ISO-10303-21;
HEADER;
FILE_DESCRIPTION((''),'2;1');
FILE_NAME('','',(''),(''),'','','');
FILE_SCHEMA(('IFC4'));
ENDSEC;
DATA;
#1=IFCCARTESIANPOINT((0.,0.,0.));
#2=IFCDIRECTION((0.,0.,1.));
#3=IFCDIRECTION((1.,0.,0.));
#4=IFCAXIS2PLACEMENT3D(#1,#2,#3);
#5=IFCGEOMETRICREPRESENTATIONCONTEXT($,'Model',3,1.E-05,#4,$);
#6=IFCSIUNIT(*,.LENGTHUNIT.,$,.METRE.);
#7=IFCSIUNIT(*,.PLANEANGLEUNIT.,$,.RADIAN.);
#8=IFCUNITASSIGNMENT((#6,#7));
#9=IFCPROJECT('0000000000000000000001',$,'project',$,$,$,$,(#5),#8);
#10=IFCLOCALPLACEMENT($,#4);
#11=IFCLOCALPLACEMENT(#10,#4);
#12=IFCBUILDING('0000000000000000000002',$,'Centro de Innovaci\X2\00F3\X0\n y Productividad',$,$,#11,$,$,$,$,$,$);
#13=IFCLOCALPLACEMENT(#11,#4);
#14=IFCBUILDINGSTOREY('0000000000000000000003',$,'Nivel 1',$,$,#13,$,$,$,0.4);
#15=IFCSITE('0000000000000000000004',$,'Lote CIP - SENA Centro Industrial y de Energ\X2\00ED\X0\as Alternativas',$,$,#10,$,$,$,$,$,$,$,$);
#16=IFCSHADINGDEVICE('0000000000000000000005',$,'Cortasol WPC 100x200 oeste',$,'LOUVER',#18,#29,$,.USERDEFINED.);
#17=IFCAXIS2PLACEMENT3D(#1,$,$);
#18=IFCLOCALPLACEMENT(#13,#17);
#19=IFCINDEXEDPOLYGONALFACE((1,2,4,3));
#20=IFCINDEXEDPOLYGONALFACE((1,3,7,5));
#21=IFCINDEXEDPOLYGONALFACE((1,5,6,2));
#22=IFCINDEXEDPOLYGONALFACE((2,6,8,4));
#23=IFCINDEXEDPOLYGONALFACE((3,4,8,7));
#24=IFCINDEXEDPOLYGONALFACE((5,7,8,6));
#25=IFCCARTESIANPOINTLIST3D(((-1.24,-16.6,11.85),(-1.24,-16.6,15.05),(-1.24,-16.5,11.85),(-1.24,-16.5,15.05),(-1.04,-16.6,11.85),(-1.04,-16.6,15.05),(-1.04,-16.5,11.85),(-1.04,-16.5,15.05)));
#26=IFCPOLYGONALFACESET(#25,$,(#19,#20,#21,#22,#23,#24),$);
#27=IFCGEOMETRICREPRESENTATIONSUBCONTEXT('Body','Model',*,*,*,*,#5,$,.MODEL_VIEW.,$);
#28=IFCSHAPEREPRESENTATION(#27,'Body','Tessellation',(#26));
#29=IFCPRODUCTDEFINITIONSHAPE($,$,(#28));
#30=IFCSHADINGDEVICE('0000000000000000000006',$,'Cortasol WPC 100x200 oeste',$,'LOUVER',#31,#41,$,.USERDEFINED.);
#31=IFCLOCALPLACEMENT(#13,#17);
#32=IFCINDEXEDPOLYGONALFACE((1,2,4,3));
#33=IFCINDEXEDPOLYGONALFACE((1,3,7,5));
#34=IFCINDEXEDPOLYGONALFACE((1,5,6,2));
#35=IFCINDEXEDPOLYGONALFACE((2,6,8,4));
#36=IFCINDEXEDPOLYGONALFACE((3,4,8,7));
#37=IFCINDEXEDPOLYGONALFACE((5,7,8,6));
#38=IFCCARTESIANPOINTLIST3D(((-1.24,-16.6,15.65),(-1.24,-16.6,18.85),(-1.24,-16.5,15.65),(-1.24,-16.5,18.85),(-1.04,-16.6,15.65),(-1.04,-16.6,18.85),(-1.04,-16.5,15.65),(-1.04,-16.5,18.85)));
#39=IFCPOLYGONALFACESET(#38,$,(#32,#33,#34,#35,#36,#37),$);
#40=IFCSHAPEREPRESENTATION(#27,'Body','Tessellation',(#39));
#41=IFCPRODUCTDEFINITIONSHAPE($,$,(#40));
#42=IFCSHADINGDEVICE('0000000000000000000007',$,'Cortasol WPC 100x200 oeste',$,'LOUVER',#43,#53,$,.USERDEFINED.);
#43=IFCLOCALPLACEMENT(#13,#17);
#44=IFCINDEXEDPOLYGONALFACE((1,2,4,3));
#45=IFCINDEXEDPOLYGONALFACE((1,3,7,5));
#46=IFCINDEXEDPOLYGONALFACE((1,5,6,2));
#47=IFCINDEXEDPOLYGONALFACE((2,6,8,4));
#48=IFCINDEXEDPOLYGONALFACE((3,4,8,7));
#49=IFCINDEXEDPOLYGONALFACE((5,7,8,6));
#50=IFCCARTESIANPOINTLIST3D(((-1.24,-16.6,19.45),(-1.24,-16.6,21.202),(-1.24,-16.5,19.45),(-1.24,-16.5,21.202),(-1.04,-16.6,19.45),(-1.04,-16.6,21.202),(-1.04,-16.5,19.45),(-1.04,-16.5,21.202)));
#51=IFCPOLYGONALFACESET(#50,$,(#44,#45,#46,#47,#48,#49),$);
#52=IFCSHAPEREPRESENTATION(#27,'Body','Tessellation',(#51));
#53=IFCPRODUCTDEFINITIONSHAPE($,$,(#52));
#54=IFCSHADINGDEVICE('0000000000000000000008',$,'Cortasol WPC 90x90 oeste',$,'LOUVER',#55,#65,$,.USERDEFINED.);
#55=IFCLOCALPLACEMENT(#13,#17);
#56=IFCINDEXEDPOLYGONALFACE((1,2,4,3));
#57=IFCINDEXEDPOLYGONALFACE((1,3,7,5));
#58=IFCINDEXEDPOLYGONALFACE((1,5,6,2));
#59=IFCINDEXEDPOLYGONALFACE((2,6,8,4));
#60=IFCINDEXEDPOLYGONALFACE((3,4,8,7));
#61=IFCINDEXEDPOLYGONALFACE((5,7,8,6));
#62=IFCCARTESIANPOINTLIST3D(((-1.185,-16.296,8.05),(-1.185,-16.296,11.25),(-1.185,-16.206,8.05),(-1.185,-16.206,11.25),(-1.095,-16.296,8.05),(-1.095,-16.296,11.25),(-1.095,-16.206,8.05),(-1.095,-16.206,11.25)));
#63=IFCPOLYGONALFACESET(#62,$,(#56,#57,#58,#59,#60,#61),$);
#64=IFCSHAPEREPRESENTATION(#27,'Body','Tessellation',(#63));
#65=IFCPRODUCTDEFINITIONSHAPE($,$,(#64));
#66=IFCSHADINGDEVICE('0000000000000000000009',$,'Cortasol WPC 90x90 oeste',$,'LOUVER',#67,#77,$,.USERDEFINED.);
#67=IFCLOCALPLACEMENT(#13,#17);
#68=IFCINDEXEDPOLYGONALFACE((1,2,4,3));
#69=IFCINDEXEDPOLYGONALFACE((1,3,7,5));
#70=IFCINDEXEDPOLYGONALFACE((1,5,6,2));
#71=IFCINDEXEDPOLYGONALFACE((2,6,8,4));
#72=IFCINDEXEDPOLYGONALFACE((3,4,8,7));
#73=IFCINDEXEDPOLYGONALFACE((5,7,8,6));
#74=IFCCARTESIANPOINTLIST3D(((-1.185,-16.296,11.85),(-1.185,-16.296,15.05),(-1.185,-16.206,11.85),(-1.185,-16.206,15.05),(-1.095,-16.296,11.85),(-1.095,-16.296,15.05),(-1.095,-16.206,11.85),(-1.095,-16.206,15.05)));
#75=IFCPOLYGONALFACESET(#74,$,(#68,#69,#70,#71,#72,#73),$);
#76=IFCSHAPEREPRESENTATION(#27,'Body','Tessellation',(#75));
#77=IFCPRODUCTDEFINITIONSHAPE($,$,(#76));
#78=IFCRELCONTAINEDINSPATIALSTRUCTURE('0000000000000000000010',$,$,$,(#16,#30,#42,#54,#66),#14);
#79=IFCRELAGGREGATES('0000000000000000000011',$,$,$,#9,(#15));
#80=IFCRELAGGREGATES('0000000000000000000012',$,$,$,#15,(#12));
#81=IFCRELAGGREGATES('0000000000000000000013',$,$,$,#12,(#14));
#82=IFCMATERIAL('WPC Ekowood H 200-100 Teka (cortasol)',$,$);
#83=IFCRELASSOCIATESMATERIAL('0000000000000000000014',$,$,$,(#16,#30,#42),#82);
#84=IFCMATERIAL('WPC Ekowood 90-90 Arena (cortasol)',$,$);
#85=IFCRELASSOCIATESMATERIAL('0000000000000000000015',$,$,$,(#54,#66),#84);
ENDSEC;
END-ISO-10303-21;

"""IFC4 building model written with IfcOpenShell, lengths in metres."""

from ifc_helpers import new_model, si_unit, frame, origin_with_axes, place, context, subcontext, project, spatial, polyline, outline, extrude, material, element, save


model = new_model("IFC4")

# Units and contexts
model_context = context("Model", 3, precision=1e-05, world=origin_with_axes())
body_context = subcontext(model_context, "Body", "Model", "MODEL_VIEW")
ifc_project = project(units=[si_unit("LENGTHUNIT", "METRE"), si_unit("PLANEANGLEUNIT", "RADIAN")], contexts=[model_context])

# Site, building, storey
site_placement = place(None, origin_with_axes())
site = spatial("IfcSite", under=ifc_project, at=site_placement, Name="Lote CIP - SENA Centro Industrial y de Energías Alternativas")
building_placement = place(site_placement, origin_with_axes())
building = spatial("IfcBuilding", under=site, at=building_placement, Name="Centro de Innovación y Productividad")
storey_placement = place(building_placement, origin_with_axes())
storey = spatial("IfcBuildingStorey", under=building, at=storey_placement, Name="Nivel 1", Elevation=0.4)

# Shading devices
ifc_material_1 = material(Name="WPC Ekowood H 200-100 Teka (cortasol)")
ifc_material_2 = material(Name="WPC Ekowood 90-90 Arena (cortasol)")
shading_device_1_placement = place(storey_placement, origin_with_axes())
element("IfcShadingDevice", 1, at=shading_device_1_placement, inside=storey, material=ifc_material_1, Name="Cortasol WPC 100x200 oeste", ObjectType="LOUVER", PredefinedType="USERDEFINED", context=body_context, shape_type="SweptSolid", body=[
    extrude(outline(polyline([(-1.04, -16.6), (-1.24, -16.6), (-1.24, -16.5), (-1.04, -16.5), (-1.04, -16.6)])), frame((0.0, 0.0, 11.85)), (0.0, 0.0, 1.0), 3.2),
])
shading_device_2_placement = place(storey_placement, origin_with_axes())
element("IfcShadingDevice", 2, at=shading_device_2_placement, inside=storey, material=ifc_material_1, Name="Cortasol WPC 100x200 oeste", ObjectType="LOUVER", PredefinedType="USERDEFINED", context=body_context, shape_type="SweptSolid", body=[
    extrude(outline(polyline([(-1.04, -16.6), (-1.24, -16.6), (-1.24, -16.5), (-1.04, -16.5), (-1.04, -16.6)])), frame((0.0, 0.0, 15.65)), (0.0, 0.0, 1.0), 3.2),
])
shading_device_3_placement = place(storey_placement, origin_with_axes())
element("IfcShadingDevice", 3, at=shading_device_3_placement, inside=storey, material=ifc_material_1, Name="Cortasol WPC 100x200 oeste", ObjectType="LOUVER", PredefinedType="USERDEFINED", context=body_context, shape_type="SweptSolid", body=[
    extrude(outline(polyline([(-1.04, -16.6), (-1.24, -16.6), (-1.24, -16.5), (-1.04, -16.5), (-1.04, -16.6)])), frame((0.0, 0.0, 19.45)), (0.0, 0.0, 1.0), 1.752),
])
shading_device_4_placement = place(storey_placement, origin_with_axes())
element("IfcShadingDevice", 4, at=shading_device_4_placement, inside=storey, material=ifc_material_2, Name="Cortasol WPC 90x90 oeste", ObjectType="LOUVER", PredefinedType="USERDEFINED", context=body_context, shape_type="SweptSolid", body=[
    extrude(outline(polyline([(-1.095, -16.296), (-1.185, -16.296), (-1.185, -16.206), (-1.095, -16.206), (-1.095, -16.296)])), frame((0.0, 0.0, 8.05)), (0.0, 0.0, 1.0), 3.2),
])
shading_device_5_placement = place(storey_placement, origin_with_axes())
element("IfcShadingDevice", 5, at=shading_device_5_placement, inside=storey, material=ifc_material_2, Name="Cortasol WPC 90x90 oeste", ObjectType="LOUVER", PredefinedType="USERDEFINED", context=body_context, shape_type="SweptSolid", body=[
    extrude(outline(polyline([(-1.095, -16.296), (-1.185, -16.296), (-1.185, -16.206), (-1.095, -16.206), (-1.095, -16.296)])), frame((0.0, 0.0, 11.85)), (0.0, 0.0, 1.0), 3.2),
])

save(model, "model.ifc")
